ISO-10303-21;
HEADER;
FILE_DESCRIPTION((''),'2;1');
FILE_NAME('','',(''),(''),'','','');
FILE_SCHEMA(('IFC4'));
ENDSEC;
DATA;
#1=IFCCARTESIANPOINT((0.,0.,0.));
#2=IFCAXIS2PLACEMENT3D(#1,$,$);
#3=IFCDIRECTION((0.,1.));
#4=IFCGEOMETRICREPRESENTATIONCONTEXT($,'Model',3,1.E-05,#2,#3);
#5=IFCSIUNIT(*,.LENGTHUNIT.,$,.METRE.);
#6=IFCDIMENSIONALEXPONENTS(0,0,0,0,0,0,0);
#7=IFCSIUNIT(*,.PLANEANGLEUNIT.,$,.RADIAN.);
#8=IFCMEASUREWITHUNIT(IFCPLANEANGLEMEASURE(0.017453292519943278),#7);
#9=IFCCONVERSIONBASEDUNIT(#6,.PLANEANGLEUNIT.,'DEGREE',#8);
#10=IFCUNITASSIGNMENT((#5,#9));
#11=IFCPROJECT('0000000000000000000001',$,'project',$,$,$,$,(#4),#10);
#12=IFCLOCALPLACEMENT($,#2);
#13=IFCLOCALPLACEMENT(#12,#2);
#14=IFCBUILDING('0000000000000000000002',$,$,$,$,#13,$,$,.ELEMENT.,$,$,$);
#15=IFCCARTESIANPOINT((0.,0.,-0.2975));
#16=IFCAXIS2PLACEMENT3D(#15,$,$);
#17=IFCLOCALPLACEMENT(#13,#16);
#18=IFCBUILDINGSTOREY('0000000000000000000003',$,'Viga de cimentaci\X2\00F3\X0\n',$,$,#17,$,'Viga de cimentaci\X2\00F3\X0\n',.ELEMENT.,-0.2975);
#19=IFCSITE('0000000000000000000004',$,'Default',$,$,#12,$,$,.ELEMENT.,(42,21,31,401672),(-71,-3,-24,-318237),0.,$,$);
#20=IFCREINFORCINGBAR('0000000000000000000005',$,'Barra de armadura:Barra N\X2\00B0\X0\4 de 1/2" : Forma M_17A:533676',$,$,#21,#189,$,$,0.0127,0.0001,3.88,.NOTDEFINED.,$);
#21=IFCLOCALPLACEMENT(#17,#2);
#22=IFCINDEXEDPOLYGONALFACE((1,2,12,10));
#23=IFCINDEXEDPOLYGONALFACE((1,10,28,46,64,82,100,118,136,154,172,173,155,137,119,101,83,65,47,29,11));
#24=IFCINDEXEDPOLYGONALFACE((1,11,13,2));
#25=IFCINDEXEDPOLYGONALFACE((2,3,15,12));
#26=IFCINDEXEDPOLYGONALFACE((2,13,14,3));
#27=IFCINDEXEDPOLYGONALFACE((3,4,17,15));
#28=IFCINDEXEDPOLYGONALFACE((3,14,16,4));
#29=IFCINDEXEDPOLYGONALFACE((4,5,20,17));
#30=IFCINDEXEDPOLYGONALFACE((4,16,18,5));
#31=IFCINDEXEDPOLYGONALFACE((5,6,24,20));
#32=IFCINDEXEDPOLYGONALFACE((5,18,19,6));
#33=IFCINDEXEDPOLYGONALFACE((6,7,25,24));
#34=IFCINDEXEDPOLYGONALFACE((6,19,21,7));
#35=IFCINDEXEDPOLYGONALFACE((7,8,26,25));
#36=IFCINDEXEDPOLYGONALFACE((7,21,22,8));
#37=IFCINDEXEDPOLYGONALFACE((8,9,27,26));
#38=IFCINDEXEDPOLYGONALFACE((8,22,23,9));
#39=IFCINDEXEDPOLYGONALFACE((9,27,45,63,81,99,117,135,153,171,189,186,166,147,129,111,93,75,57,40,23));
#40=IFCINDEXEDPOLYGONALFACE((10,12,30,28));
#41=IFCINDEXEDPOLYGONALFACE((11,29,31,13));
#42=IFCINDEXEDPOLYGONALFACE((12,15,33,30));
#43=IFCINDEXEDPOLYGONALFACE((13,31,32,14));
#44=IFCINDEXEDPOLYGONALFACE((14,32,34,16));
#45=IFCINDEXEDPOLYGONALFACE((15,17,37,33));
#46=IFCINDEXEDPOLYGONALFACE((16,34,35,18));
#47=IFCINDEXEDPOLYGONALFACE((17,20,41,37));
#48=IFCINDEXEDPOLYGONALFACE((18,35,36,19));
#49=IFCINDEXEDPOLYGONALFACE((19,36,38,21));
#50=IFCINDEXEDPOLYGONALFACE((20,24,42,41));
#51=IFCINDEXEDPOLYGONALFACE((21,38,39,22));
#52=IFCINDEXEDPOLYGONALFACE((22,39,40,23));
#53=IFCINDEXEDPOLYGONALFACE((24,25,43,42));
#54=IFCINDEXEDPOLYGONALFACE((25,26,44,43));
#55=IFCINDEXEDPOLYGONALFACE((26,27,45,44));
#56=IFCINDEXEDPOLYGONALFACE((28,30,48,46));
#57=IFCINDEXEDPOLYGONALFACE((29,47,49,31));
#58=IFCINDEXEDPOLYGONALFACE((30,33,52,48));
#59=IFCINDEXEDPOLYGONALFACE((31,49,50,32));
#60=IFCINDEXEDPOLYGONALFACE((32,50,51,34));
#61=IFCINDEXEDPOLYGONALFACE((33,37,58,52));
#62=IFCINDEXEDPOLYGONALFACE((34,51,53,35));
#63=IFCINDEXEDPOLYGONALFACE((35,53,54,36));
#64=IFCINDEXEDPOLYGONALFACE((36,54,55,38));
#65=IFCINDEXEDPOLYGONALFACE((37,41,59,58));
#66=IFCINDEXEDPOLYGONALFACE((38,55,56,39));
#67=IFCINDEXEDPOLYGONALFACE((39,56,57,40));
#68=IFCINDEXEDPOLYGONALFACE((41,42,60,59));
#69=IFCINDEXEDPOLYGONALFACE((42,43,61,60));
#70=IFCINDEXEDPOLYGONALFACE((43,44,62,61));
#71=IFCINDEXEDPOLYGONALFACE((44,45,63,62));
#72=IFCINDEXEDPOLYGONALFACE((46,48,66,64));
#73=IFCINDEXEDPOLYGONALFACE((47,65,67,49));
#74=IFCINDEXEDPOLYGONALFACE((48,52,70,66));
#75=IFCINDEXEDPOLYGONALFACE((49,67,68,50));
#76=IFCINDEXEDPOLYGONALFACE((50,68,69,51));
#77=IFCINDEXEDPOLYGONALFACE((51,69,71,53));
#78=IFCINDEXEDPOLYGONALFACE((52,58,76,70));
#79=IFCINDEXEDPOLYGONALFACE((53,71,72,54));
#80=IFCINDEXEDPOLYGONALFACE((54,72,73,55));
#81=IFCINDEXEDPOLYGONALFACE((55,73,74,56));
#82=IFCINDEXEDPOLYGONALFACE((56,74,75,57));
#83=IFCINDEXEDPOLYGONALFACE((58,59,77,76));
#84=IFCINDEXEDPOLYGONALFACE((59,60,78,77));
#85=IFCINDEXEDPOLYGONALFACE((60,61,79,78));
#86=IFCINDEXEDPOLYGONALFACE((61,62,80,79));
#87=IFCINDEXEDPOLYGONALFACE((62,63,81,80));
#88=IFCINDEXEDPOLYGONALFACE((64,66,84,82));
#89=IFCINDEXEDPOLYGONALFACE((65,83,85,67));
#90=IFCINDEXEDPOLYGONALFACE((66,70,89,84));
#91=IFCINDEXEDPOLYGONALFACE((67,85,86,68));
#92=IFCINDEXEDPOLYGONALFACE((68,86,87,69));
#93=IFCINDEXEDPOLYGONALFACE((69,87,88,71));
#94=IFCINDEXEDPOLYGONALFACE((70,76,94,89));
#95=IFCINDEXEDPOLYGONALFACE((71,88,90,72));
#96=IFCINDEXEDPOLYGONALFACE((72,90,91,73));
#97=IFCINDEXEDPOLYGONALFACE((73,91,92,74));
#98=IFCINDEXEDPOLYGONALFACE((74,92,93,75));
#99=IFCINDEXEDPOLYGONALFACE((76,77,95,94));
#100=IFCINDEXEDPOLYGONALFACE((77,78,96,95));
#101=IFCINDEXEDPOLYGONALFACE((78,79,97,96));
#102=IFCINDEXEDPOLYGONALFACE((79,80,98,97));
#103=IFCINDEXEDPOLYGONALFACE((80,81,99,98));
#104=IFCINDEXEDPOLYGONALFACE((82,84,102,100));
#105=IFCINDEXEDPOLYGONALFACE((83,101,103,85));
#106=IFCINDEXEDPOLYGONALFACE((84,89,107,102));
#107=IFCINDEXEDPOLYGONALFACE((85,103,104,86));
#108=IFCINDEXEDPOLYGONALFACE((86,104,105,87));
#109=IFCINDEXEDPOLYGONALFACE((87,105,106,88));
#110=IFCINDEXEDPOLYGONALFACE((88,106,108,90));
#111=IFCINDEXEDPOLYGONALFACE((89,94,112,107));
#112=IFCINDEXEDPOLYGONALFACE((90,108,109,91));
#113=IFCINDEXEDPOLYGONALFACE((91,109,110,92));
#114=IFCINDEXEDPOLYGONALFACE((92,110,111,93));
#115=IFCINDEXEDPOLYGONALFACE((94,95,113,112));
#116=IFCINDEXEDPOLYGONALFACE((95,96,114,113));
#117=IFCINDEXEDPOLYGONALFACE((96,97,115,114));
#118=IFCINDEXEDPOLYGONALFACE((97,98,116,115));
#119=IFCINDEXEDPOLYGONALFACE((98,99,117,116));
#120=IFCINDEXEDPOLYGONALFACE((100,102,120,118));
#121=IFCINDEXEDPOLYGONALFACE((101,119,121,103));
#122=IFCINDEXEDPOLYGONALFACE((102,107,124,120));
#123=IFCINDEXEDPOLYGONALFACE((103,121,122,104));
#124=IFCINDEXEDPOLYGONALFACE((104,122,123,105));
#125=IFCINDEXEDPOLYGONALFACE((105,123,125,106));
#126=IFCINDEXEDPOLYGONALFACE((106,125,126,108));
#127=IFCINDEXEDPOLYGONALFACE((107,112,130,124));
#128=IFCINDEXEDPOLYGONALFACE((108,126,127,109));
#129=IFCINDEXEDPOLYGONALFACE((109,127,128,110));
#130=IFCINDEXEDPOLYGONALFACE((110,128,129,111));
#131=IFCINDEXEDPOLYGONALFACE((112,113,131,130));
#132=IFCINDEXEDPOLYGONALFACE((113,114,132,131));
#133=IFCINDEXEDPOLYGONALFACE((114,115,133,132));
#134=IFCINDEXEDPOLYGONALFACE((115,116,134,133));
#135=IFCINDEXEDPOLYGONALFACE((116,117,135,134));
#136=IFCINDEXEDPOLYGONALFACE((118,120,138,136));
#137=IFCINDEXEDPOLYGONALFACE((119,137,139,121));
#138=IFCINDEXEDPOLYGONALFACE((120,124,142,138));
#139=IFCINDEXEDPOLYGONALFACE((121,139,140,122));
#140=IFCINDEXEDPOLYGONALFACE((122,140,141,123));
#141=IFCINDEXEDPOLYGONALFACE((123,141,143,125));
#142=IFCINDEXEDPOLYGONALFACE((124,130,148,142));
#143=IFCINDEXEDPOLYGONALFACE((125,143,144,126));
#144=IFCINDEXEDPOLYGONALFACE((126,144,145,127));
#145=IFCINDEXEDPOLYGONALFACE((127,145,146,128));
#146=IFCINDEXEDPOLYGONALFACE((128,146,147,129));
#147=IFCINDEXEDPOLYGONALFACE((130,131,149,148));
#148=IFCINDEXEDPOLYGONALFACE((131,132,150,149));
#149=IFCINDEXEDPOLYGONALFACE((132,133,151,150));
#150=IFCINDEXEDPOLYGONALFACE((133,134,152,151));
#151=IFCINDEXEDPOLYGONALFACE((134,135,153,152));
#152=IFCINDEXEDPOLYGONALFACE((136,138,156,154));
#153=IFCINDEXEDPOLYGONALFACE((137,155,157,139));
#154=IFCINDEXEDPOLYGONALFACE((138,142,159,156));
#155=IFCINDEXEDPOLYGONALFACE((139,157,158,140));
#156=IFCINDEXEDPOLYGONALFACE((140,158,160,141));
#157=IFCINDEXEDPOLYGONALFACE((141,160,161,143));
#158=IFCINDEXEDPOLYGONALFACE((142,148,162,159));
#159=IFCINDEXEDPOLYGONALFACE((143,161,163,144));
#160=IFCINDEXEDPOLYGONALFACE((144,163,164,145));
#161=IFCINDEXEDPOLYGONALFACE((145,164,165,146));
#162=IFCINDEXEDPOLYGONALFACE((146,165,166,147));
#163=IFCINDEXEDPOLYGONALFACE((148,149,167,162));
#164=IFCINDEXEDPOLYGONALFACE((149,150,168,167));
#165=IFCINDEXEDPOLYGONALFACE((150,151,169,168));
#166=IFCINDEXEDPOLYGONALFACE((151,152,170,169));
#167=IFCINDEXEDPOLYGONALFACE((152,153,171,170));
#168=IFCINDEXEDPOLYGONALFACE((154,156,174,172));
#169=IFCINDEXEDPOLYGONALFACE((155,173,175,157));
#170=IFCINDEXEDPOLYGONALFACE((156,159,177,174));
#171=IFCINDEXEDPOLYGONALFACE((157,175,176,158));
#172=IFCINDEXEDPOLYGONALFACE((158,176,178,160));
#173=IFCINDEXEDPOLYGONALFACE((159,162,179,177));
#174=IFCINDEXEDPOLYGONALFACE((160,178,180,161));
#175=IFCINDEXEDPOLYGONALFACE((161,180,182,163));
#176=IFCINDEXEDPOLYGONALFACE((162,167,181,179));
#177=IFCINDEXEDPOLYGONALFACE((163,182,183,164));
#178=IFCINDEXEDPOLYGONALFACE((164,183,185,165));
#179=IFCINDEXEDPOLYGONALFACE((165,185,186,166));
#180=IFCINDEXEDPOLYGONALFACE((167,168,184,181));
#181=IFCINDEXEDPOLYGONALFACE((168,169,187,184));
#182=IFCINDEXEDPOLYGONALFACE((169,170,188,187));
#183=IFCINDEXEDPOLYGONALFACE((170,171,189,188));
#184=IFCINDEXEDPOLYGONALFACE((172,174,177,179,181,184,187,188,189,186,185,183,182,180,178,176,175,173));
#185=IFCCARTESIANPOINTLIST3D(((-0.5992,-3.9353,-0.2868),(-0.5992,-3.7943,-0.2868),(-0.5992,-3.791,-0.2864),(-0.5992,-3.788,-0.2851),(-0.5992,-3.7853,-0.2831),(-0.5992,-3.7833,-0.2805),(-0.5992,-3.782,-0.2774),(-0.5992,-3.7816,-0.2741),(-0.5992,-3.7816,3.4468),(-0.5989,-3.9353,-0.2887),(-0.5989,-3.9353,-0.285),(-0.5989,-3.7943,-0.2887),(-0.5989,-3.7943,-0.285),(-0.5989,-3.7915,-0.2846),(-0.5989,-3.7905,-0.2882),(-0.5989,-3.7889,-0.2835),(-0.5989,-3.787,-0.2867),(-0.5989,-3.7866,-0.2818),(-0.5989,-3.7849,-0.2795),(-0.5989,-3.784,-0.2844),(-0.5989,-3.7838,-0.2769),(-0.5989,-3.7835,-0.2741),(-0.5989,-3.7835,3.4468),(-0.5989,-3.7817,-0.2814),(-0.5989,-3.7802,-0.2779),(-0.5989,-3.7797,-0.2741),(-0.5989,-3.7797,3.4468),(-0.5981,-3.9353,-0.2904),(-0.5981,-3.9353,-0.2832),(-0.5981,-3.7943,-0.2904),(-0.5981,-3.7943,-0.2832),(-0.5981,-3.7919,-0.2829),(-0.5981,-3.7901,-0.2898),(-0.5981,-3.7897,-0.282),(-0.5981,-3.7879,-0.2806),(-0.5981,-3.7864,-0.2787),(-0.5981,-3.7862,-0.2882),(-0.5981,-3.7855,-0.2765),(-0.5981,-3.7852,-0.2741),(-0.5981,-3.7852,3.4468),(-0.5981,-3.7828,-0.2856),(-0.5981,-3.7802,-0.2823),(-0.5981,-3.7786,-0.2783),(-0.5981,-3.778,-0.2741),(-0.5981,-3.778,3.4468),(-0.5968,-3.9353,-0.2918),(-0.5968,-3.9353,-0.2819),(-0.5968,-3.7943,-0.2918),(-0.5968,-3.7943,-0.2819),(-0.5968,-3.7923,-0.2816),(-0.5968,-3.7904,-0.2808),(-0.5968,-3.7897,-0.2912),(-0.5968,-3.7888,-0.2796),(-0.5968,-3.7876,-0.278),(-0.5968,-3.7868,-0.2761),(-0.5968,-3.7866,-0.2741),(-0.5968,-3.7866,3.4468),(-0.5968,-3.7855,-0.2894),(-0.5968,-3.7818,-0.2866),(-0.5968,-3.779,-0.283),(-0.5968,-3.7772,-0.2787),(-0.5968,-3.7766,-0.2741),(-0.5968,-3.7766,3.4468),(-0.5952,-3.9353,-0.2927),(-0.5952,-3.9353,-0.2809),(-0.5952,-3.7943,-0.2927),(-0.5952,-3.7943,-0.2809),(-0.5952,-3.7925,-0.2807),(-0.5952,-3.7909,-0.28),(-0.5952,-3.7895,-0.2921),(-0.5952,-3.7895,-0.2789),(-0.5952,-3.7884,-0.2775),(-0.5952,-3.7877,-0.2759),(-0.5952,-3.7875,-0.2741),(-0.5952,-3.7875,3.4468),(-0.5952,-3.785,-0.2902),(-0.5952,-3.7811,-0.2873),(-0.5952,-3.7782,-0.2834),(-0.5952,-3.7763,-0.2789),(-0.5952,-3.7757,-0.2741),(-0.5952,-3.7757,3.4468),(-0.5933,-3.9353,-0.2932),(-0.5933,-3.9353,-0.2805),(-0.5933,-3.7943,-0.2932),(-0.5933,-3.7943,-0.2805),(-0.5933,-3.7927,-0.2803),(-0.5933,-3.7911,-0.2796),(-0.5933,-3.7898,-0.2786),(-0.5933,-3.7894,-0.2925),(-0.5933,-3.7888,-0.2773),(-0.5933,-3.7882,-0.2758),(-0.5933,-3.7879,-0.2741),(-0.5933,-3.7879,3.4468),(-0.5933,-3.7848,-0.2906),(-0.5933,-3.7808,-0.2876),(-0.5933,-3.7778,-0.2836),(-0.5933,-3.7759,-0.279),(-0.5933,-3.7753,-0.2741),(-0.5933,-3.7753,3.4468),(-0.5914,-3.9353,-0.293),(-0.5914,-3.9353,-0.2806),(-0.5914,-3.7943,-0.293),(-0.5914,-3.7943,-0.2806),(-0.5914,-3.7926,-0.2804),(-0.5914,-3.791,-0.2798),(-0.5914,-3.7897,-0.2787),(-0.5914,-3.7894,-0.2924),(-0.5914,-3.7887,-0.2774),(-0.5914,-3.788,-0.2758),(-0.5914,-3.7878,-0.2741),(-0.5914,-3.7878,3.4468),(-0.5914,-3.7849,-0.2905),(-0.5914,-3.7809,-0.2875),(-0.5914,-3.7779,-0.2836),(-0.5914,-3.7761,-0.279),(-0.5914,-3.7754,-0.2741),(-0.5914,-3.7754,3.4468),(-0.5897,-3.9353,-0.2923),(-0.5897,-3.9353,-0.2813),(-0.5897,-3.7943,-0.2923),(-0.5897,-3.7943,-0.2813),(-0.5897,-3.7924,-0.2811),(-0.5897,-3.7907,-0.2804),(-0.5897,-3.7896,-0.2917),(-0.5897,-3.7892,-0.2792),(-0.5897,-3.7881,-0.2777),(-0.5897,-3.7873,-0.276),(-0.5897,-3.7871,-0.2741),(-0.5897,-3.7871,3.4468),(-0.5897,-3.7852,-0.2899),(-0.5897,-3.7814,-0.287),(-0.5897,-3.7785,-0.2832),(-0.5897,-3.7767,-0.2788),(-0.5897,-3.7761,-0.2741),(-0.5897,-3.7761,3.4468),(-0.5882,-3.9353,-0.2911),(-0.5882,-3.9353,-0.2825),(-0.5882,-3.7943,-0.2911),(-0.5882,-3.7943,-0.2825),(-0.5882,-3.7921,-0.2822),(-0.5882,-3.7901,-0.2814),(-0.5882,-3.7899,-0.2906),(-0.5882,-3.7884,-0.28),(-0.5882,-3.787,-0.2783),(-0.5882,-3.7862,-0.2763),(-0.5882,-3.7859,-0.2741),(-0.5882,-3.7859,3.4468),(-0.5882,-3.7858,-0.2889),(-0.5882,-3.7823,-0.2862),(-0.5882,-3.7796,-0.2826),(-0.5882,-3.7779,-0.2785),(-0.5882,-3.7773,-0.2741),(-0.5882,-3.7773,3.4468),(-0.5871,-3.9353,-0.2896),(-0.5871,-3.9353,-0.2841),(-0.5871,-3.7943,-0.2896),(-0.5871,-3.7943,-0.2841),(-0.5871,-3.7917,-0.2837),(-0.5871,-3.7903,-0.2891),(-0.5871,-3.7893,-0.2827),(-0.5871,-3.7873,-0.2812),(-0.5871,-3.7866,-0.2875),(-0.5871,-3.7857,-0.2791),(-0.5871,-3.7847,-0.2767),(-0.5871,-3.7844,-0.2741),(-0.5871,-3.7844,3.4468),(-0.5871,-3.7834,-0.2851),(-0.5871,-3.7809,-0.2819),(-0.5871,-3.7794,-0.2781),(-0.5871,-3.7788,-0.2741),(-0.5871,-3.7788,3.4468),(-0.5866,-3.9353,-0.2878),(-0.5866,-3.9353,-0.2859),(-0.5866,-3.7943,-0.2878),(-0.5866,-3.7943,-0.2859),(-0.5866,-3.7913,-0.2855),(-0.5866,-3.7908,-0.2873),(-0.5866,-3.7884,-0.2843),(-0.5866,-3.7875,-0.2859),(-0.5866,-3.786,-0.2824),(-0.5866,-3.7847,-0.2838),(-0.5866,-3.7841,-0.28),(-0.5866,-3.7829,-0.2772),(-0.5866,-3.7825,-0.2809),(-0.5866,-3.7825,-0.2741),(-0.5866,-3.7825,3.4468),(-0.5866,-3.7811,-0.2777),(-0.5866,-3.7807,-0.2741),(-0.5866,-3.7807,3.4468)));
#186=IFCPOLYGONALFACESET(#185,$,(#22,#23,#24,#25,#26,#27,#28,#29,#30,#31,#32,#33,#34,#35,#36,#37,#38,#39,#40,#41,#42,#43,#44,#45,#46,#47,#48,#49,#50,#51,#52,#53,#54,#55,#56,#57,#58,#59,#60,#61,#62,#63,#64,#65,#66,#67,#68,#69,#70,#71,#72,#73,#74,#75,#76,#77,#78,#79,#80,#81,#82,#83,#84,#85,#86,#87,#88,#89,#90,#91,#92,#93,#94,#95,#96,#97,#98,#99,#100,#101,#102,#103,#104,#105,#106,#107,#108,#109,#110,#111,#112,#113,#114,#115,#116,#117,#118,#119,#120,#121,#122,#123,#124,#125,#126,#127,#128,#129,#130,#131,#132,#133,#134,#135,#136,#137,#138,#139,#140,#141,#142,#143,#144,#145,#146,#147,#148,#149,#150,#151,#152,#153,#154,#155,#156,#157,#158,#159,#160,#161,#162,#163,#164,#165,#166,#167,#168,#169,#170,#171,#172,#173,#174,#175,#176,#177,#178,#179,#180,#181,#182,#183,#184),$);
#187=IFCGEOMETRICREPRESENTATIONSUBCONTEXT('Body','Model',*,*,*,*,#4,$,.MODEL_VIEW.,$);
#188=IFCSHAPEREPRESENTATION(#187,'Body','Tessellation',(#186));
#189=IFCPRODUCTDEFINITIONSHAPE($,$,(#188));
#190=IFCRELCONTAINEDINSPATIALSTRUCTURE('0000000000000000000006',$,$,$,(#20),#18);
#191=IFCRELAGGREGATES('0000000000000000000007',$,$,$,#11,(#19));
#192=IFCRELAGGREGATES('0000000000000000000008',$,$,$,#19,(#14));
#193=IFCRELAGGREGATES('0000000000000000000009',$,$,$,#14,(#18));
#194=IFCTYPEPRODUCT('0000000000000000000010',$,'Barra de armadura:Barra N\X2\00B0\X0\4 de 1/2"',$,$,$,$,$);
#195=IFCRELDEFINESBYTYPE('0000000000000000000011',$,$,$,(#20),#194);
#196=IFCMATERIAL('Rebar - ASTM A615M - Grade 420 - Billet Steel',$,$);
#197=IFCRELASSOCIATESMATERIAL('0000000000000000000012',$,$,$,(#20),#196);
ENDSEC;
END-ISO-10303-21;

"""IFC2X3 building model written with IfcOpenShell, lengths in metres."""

from ifc_helpers import new_model, entity, si_unit, converted_unit, direction, frame, origin, place, context, subcontext, project, spatial, material, type_object, element, save


model = new_model("IFC2X3")

# Units and contexts
model_context = context("Model", 3, precision=1e-05, world=origin(), true_north=direction((0.0, 1.0)))
body_context = subcontext(model_context, "Body", "Model", "MODEL_VIEW")
ifc_project = project(units=[si_unit("LENGTHUNIT", "METRE"), converted_unit("PLANEANGLEUNIT", "DEGREE", entity("IfcPlaneAngleMeasure", 0.017453292519943278), si_unit("PLANEANGLEUNIT", "RADIAN"), dimensions=[0, 0, 0, 0, 0, 0, 0])], contexts=[model_context])

# Site, building, storey
site_placement = place(None, origin())
site = spatial("IfcSite", under=ifc_project, at=site_placement, Name="Default", CompositionType="ELEMENT", RefLatitude=(42, 21, 31, 401672), RefLongitude=(-71, -3, -24, -318237), RefElevation=0.0)
building_placement = place(site_placement, origin())
building = spatial("IfcBuilding", under=site, at=building_placement, CompositionType="ELEMENT")
storey_placement = place(building_placement, frame((0.0, 0.0, -0.2975)))
storey = spatial("IfcBuildingStorey", under=building, at=storey_placement, Name="Viga de cimentación", LongName="Viga de cimentación", CompositionType="ELEMENT", Elevation=-0.2975)

# Reinforcing bar
ifc_material = material(Name="Rebar - ASTM A615M - Grade 420 - Billet Steel")
type_product_1 = type_object("IfcTypeProduct", Name="Barra de armadura:Barra N°4 de 1/2\"")
reinforcing_bar_1_placement = place(storey_placement, origin())
element("IfcReinforcingBar", 1, at=reinforcing_bar_1_placement, inside=storey, type_object=type_product_1, material=ifc_material, Name="Barra de armadura:Barra N°4 de 1/2\" : Forma M_17A:533676", BarLength=3.88, BarRole="NOTDEFINED", CrossSectionArea=0.0001, NominalDiameter=0.0127, context=body_context, shape_type="AdvancedSweptSolid", body=[
    entity("IfcSweptDiskSolid", entity("IfcCompositeCurve", [entity("IfcCompositeCurveSegment", "CONTINUOUS", True, entity("IfcPolyline", [entity("IfcCartesianPoint", [-0.5929, -3.7816, 3.4468]), entity("IfcCartesianPoint", [-0.5929, -3.7816, -0.2741])])), entity("IfcCompositeCurveSegment", "CONTINUOUS", True, entity("IfcTrimmedCurve", entity("IfcCircle", entity("IfcAxis2Placement3D", entity("IfcCartesianPoint", [-0.5929, -3.7943, -0.2741]), entity("IfcDirection", [-1.0, 0.0, 0.0]), entity("IfcDirection", [0.0, 0.0, -1.0])), 0.0127), [entity("IfcParameterValue", 270.0)], [entity("IfcParameterValue", 360.0)], True, "PARAMETER")), entity("IfcCompositeCurveSegment", "CONTINUOUS", True, entity("IfcPolyline", [entity("IfcCartesianPoint", [-0.5929, -3.7943, -0.2868]), entity("IfcCartesianPoint", [-0.5929, -3.9353, -0.2868])]))], False), 0.0063, None, 0.0, 92.0),
])

save(model, "model.ifc")
